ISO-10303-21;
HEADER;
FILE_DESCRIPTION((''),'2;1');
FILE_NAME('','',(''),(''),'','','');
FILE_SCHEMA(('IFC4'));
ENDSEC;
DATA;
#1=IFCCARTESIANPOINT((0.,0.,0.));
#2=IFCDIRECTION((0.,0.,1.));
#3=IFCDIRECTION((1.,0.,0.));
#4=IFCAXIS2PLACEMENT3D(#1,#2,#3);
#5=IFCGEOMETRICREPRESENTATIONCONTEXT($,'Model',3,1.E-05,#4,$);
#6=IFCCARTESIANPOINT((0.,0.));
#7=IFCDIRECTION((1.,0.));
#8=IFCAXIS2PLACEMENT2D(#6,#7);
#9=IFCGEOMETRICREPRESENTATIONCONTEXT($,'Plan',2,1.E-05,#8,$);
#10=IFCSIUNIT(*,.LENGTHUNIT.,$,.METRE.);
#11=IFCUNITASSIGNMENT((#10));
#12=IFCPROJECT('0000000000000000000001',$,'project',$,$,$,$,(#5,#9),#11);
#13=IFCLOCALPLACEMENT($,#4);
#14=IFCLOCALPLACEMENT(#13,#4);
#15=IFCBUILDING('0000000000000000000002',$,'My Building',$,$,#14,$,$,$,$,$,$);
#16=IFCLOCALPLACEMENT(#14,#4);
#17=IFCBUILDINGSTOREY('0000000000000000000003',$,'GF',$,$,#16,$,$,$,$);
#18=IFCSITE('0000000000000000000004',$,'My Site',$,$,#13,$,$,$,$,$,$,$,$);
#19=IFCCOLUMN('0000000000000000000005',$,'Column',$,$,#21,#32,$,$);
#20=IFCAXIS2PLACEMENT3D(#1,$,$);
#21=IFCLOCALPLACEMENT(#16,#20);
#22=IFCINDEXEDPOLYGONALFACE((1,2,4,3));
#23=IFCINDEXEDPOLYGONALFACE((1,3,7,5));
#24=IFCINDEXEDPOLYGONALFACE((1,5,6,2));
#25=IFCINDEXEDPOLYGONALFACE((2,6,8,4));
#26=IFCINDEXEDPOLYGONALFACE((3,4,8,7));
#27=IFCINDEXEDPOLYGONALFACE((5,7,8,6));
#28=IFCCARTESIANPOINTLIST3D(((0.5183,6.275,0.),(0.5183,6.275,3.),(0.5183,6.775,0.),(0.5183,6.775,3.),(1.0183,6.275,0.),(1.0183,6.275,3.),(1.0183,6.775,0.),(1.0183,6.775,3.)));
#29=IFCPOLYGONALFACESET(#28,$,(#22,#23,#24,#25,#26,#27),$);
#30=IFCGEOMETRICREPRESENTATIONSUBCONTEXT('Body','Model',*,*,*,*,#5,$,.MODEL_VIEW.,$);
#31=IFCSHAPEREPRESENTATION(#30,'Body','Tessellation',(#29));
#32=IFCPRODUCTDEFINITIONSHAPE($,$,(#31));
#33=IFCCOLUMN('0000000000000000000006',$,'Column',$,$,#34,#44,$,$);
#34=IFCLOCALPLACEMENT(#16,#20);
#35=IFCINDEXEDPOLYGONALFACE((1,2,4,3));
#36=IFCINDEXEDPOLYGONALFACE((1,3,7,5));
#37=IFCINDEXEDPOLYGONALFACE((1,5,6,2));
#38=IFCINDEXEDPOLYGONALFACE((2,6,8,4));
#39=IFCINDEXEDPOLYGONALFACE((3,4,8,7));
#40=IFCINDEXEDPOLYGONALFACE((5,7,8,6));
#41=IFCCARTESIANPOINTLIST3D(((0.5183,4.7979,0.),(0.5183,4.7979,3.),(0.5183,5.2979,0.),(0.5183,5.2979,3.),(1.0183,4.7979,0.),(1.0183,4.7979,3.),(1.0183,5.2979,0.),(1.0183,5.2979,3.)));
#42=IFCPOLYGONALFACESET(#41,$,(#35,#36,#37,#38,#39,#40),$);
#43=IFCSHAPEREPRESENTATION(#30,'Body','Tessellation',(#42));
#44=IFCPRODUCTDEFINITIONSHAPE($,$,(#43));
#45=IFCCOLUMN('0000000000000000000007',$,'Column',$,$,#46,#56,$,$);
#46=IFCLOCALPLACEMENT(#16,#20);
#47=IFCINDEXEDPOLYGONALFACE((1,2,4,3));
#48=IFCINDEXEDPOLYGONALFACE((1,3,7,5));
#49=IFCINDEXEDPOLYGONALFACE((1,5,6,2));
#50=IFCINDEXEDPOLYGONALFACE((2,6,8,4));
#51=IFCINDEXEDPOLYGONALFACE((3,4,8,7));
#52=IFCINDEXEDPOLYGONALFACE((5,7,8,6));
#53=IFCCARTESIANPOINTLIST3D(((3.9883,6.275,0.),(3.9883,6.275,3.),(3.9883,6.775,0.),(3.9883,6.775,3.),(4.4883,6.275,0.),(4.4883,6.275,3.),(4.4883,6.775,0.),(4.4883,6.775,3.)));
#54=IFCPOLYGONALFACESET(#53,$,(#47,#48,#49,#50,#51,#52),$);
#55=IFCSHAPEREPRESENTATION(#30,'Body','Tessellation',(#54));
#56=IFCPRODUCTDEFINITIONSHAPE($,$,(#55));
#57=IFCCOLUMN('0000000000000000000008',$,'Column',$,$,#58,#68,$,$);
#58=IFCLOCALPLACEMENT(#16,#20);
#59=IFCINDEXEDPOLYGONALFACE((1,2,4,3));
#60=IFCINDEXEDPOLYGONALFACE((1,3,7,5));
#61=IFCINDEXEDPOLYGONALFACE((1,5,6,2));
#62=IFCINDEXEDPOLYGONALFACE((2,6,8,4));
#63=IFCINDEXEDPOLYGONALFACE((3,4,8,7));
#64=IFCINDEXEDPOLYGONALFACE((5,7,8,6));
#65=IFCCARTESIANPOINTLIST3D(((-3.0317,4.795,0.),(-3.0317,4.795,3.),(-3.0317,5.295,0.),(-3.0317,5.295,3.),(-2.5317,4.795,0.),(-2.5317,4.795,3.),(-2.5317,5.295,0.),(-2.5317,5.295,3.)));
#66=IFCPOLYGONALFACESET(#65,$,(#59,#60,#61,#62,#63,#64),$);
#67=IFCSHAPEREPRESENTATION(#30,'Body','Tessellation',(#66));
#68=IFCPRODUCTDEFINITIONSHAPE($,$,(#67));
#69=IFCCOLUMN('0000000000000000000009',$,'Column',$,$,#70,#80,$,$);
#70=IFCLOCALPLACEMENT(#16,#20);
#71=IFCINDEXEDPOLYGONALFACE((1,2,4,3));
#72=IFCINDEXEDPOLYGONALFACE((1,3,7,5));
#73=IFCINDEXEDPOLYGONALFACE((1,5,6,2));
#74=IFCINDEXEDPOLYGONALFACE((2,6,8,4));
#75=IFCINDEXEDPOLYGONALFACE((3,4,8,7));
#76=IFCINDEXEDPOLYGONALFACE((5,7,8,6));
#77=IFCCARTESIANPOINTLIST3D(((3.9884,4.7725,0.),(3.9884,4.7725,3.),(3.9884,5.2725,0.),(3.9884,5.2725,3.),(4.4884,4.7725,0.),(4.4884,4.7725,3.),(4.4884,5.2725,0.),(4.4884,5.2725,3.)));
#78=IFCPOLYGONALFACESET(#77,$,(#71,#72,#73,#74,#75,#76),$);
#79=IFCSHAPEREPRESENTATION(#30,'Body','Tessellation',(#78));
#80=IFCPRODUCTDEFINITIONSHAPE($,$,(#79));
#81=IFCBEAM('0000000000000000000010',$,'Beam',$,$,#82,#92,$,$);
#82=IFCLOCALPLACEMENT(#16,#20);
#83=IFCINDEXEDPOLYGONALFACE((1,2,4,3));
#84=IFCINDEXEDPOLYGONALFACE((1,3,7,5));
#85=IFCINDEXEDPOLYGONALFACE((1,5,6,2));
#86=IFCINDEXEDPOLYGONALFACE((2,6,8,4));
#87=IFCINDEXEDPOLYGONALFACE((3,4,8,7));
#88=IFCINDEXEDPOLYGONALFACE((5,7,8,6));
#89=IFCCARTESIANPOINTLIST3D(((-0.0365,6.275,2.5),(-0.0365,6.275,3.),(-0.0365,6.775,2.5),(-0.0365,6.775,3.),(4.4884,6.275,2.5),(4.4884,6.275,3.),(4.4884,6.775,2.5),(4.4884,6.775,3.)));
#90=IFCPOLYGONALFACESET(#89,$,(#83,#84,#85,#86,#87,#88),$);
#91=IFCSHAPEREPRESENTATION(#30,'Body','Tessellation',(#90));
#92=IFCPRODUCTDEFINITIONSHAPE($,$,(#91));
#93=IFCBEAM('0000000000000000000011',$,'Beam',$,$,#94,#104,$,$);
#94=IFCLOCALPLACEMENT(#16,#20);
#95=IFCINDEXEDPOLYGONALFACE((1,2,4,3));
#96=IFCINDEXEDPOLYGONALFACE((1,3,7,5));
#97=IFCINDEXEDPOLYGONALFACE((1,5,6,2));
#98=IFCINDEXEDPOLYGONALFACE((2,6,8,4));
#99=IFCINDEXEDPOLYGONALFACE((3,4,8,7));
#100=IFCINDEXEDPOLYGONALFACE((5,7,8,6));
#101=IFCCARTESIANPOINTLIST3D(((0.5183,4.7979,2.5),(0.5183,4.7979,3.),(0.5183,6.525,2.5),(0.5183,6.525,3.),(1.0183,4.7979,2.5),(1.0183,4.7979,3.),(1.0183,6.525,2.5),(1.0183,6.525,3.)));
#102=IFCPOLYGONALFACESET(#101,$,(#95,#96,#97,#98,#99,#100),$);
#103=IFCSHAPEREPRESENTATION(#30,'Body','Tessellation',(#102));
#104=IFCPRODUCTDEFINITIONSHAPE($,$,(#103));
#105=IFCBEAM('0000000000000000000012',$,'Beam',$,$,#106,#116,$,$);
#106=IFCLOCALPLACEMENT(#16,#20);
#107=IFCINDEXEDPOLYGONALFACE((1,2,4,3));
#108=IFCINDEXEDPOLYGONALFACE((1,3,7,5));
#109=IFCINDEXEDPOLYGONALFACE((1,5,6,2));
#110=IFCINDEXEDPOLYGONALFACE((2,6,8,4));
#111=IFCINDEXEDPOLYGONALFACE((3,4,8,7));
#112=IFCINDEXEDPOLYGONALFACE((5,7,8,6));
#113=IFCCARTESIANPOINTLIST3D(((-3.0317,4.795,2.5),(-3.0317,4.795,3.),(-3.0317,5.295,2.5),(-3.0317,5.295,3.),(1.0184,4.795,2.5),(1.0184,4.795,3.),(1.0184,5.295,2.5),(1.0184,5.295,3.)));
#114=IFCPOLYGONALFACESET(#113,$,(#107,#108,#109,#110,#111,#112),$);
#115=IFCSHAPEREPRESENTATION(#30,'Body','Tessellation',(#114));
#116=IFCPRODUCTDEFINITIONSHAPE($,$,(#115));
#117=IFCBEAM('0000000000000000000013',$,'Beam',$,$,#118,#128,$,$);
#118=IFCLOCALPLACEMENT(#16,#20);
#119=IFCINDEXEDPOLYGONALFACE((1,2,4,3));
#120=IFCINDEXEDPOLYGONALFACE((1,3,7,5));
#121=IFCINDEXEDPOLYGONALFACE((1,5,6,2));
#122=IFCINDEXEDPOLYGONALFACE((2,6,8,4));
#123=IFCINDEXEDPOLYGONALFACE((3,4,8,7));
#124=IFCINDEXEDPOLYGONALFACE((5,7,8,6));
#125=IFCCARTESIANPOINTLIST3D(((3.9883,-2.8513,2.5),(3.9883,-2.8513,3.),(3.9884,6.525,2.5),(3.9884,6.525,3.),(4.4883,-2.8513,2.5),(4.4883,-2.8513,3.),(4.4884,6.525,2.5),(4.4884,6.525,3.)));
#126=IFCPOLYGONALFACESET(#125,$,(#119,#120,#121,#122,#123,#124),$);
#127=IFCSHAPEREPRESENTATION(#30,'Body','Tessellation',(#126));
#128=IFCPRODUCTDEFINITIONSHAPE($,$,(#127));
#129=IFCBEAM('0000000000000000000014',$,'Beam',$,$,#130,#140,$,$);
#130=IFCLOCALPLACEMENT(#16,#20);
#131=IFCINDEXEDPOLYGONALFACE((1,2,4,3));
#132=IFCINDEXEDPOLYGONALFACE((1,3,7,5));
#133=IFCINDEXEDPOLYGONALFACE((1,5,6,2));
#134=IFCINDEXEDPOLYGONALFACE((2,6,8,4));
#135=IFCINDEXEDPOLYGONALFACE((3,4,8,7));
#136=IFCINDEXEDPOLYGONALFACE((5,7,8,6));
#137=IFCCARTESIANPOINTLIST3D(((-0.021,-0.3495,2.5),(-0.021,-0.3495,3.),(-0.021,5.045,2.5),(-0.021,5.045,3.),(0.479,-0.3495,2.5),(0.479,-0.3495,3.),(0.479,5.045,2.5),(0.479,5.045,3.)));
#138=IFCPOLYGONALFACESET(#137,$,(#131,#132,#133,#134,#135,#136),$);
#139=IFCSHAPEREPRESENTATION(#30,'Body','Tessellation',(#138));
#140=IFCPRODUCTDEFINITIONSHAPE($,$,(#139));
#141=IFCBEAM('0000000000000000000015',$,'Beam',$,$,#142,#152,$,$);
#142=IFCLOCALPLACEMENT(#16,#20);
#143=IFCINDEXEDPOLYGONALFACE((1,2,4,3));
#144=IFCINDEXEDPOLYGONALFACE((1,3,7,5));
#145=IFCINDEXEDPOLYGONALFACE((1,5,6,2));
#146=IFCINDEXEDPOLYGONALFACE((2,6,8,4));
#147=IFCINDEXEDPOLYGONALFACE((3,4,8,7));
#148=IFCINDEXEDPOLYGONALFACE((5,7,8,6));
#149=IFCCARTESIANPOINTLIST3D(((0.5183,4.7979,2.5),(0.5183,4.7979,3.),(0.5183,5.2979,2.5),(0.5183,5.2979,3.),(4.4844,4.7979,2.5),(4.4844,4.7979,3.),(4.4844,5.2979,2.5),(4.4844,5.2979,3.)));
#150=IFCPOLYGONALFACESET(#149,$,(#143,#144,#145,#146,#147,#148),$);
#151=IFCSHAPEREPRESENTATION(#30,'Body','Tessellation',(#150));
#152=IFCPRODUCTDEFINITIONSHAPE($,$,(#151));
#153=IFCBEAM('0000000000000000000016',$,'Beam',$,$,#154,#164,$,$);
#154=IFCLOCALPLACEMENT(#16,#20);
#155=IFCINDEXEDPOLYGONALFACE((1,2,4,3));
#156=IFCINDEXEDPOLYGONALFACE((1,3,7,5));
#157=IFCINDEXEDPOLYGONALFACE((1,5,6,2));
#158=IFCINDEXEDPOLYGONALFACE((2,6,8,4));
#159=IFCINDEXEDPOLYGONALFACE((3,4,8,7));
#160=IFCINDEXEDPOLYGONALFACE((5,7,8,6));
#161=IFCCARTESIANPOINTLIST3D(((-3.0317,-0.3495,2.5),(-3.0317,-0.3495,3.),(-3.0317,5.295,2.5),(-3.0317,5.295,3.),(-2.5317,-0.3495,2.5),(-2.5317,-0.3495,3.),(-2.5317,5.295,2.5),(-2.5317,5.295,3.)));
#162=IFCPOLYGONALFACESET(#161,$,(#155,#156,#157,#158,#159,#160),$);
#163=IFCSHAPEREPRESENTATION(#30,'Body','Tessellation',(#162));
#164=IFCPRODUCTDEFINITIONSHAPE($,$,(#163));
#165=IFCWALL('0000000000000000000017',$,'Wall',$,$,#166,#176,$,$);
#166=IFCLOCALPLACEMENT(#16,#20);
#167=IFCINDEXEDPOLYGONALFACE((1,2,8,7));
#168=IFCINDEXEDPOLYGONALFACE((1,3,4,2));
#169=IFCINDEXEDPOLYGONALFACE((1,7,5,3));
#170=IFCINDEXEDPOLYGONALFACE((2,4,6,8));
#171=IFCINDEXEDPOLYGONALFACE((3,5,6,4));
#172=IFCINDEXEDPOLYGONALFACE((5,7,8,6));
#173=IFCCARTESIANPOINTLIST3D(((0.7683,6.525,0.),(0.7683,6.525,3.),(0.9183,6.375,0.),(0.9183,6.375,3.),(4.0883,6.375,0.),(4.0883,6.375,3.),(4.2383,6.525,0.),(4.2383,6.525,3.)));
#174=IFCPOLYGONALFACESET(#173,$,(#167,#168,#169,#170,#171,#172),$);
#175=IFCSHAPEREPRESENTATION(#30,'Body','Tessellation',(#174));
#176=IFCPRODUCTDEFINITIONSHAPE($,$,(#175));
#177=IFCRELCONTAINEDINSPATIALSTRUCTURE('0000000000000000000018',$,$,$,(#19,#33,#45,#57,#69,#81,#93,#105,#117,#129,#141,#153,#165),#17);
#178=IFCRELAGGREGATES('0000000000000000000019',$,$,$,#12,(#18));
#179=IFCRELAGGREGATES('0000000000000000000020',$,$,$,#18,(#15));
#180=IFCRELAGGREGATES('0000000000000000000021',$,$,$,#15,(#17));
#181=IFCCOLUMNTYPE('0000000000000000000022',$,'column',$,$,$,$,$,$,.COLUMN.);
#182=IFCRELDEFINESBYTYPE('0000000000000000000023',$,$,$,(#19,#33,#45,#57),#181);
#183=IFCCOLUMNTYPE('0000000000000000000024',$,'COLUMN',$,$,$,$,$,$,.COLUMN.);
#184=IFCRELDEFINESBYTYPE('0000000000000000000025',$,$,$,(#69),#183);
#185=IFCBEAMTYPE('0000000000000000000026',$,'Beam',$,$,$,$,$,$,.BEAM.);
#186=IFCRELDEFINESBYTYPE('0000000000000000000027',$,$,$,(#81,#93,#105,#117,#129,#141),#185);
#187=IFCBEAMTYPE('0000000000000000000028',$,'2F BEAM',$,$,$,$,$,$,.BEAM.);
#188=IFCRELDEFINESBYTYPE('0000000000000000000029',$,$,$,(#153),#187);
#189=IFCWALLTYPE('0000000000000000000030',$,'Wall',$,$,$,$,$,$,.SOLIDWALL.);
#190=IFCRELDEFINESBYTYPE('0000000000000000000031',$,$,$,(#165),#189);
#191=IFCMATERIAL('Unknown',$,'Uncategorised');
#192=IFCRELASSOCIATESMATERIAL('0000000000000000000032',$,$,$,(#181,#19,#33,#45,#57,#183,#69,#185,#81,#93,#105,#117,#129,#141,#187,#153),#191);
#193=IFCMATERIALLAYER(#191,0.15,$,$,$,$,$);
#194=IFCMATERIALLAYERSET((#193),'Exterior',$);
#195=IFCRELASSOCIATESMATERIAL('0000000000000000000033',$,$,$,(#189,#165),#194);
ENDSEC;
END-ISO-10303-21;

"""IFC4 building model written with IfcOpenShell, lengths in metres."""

from ifc_helpers import new_model, si_unit, frame, origin_with_axes, origin_2d_with_axis, place, context, subcontext, project, spatial, line, indexed_curve, rectangle, outline, extrude, material, layer, layer_set, layer_usage, material_profile, profile_set, profile_usage, type_object, element, save


model = new_model("IFC4")

# Units and contexts
model_context = context("Model", 3, precision=1e-05, world=origin_with_axes())
plan_context = context("Plan", 2, precision=1e-05, world=origin_2d_with_axis())
body_context_1 = subcontext(model_context, "Body", "Model", "MODEL_VIEW")
ifc_project = project(units=[si_unit("LENGTHUNIT", "METRE")], contexts=[model_context, plan_context])

# Site, building, storey
site_placement = place(None, origin_with_axes())
site = spatial("IfcSite", under=ifc_project, at=site_placement, Name="My Site")
building_placement = place(site_placement, origin_with_axes())
building = spatial("IfcBuilding", under=site, at=building_placement, Name="My Building")
storey_placement = place(building_placement, origin_with_axes())
storey = spatial("IfcBuildingStorey", under=building, at=storey_placement, Name="GF")

# Columns
ifc_material = material(Name="Unknown", Category="Uncategorised")
ifc_material_profile_1 = material_profile(ifc_material, rectangle(XDim=0.5, YDim=0.5))
ifc_profile_set_1 = profile_set([ifc_material_profile_1])
ifc_profile_usage_1 = profile_usage(ifc_profile_set_1, cardinal=5)
column_type_1 = type_object("IfcColumnType", Name="column", PredefinedType="COLUMN", material=ifc_profile_set_1)
column_1_placement = place(storey_placement, frame((0.7683, 6.525, 0.0), z_axis=(0.0, 0.0, 1.0), x_axis=(1.0, 0.0, 0.0)))
element("IfcColumn", 1, at=column_1_placement, inside=storey, type_object=column_type_1, material=ifc_profile_usage_1, Name="Column", context=body_context_1, shape_type="SweptSolid", body=[
    extrude(rectangle(XDim=0.5, YDim=0.5), origin_with_axes(), (0.0, 0.0, 1.0), 3.0),
])
ifc_profile_usage_2 = profile_usage(ifc_profile_set_1, cardinal=5)
column_2_placement = place(storey_placement, frame((0.7683, 5.0479, 0.0), z_axis=(0.0, 0.0, 1.0), x_axis=(1.0, 0.0, 0.0)))
element("IfcColumn", 2, at=column_2_placement, inside=storey, type_object=column_type_1, material=ifc_profile_usage_2, Name="Column", context=body_context_1, shape_type="SweptSolid", body=[
    extrude(rectangle(XDim=0.5, YDim=0.5), origin_with_axes(), (0.0, 0.0, 1.0), 3.0),
])
ifc_profile_usage_3 = profile_usage(ifc_profile_set_1, cardinal=5)
column_3_placement = place(storey_placement, frame((4.2383, 6.525, 0.0), z_axis=(0.0, 0.0, 1.0), x_axis=(1.0, 0.0, 0.0)))
element("IfcColumn", 3, at=column_3_placement, inside=storey, type_object=column_type_1, material=ifc_profile_usage_3, Name="Column", context=body_context_1, shape_type="SweptSolid", body=[
    extrude(rectangle(XDim=0.5, YDim=0.5), origin_with_axes(), (0.0, 0.0, 1.0), 3.0),
])
ifc_profile_usage_4 = profile_usage(ifc_profile_set_1, cardinal=5)
column_4_placement = place(storey_placement, frame((-2.7817, 5.045, 0.0), z_axis=(0.0, 0.0, 1.0), x_axis=(1.0, 0.0, 0.0)))
element("IfcColumn", 4, at=column_4_placement, inside=storey, type_object=column_type_1, material=ifc_profile_usage_4, Name="Column", context=body_context_1, shape_type="SweptSolid", body=[
    extrude(rectangle(XDim=0.5, YDim=0.5), origin_with_axes(), (0.0, 0.0, 1.0), 3.0),
])
ifc_material_profile_2 = material_profile(ifc_material, rectangle(XDim=0.5, YDim=0.5))
ifc_profile_set_2 = profile_set([ifc_material_profile_2])
ifc_profile_usage_5 = profile_usage(ifc_profile_set_2, cardinal=5)
column_type_2 = type_object("IfcColumnType", Name="COLUMN", PredefinedType="COLUMN", material=ifc_profile_set_2)
column_5_placement = place(storey_placement, frame((4.2384, 5.0225, 0.0), z_axis=(0.0, 0.0, 1.0), x_axis=(1.0, 0.0, 0.0)))
element("IfcColumn", 5, at=column_5_placement, inside=storey, type_object=column_type_2, material=ifc_profile_usage_5, Name="Column", context=body_context_1, shape_type="SweptSolid", body=[
    extrude(rectangle(XDim=0.5, YDim=0.5), origin_with_axes(), (0.0, 0.0, 1.0), 3.0),
])

# Beams
ifc_material_profile_3 = material_profile(ifc_material, rectangle(XDim=0.5, YDim=0.5))
ifc_profile_set_3 = profile_set([ifc_material_profile_3])
ifc_profile_usage_6 = profile_usage(ifc_profile_set_3, cardinal=5)
beam_type_1 = type_object("IfcBeamType", Name="Beam", PredefinedType="BEAM", material=ifc_profile_set_3)
beam_1_placement = place(storey_placement, frame((4.4884, 6.525, 2.75), z_axis=(-1.0, 0.0, 0.0), x_axis=(0.0, -1.0, 0.0)))
element("IfcBeam", 6, at=beam_1_placement, inside=storey, type_object=beam_type_1, material=ifc_profile_usage_6, Name="Beam", context=body_context_1, shape_type="SweptSolid", body=[
    extrude(rectangle(XDim=0.5, YDim=0.5), origin_with_axes(), (0.0, 0.0, 1.0), 4.5249),
])
ifc_profile_usage_7 = profile_usage(ifc_profile_set_3, cardinal=5)
beam_2_placement = place(storey_placement, frame((0.7683, 6.525, 2.75), z_axis=(0.0, -1.0, 0.0), x_axis=(1.0, 0.0, 0.0)))
element("IfcBeam", 7, at=beam_2_placement, inside=storey, type_object=beam_type_1, material=ifc_profile_usage_7, Name="Beam", context=body_context_1, shape_type="SweptSolid", body=[
    extrude(rectangle(XDim=0.5, YDim=0.5), origin_with_axes(), (0.0, 0.0, 1.0), 1.7271),
])
ifc_profile_usage_8 = profile_usage(ifc_profile_set_3, cardinal=5)
beam_3_placement = place(storey_placement, frame((-3.0317, 5.045, 2.75), z_axis=(1.0, 0.0, 0.0), x_axis=(0.0, 1.0, 0.0)))
element("IfcBeam", 8, at=beam_3_placement, inside=storey, type_object=beam_type_1, material=ifc_profile_usage_8, Name="Beam", context=body_context_1, shape_type="SweptSolid", body=[
    extrude(rectangle(XDim=0.5, YDim=0.5), origin_with_axes(), (0.0, 0.0, 1.0), 4.05),
])
ifc_profile_usage_9 = profile_usage(ifc_profile_set_3, cardinal=5)
beam_4_placement = place(storey_placement, frame((4.2384, 6.525, 2.75), z_axis=(0.0, -1.0, 0.0), x_axis=(1.0, 0.0, 0.0)))
element("IfcBeam", 9, at=beam_4_placement, inside=storey, type_object=beam_type_1, material=ifc_profile_usage_9, Name="Beam", context=body_context_1, shape_type="SweptSolid", body=[
    extrude(rectangle(XDim=0.5, YDim=0.5), origin_with_axes(), (0.0, 0.0, 1.0), 9.3763),
])
ifc_profile_usage_10 = profile_usage(ifc_profile_set_3, cardinal=5)
beam_5_placement = place(storey_placement, frame((0.229, 5.045, 2.75), z_axis=(0.0, -1.0, 0.0), x_axis=(1.0, 0.0, 0.0)))
element("IfcBeam", 10, at=beam_5_placement, inside=storey, type_object=beam_type_1, material=ifc_profile_usage_10, Name="Beam", context=body_context_1, shape_type="SweptSolid", body=[
    extrude(rectangle(XDim=0.5, YDim=0.5), origin_with_axes(), (0.0, 0.0, 1.0), 5.3945),
])
ifc_profile_usage_11 = profile_usage(ifc_profile_set_3, cardinal=5)
beam_6_placement = place(storey_placement, frame((0.5183, 5.0479, 2.75), z_axis=(1.0, 0.0, 0.0), x_axis=(0.0, 1.0, 0.0)))
element("IfcBeam", 11, at=beam_6_placement, inside=storey, type_object=beam_type_1, material=ifc_profile_usage_11, Name="Beam", context=body_context_1, shape_type="SweptSolid", body=[
    extrude(rectangle(XDim=0.5, YDim=0.5), origin_with_axes(), (0.0, 0.0, 1.0), 3.966),
])
ifc_material_profile_4 = material_profile(ifc_material, rectangle(XDim=0.5, YDim=0.5))
ifc_profile_set_4 = profile_set([ifc_material_profile_4])
ifc_profile_usage_12 = profile_usage(ifc_profile_set_4, cardinal=5)
beam_type_2 = type_object("IfcBeamType", Name="2F BEAM", PredefinedType="BEAM", material=ifc_profile_set_4)
beam_7_placement = place(storey_placement, frame((-2.7817, 5.295, 2.75), z_axis=(0.0, -1.0, 0.0), x_axis=(1.0, 0.0, 0.0)))
element("IfcBeam", 12, at=beam_7_placement, inside=storey, type_object=beam_type_2, material=ifc_profile_usage_12, Name="Beam", context=body_context_1, shape_type="SweptSolid", body=[
    extrude(rectangle(XDim=0.5, YDim=0.5), origin_with_axes(), (0.0, 0.0, 1.0), 5.6445),
])

# Wall
ifc_layer_1 = layer(ifc_material, 0.15)
ifc_layer_set_1 = layer_set([ifc_layer_1], Name="Exterior")
ifc_layer_usage_1 = layer_usage(ifc_layer_set_1, "AXIS2", "POSITIVE", 0.0)
wall_type_1 = type_object("IfcWallType", Name="Wall", PredefinedType="SOLIDWALL", material=ifc_layer_set_1)
wall_1_placement = place(storey_placement, frame((4.2383, 6.525, 0.0), z_axis=(0.0, 0.0, 1.0), x_axis=(-1.0, 0.0, 0.0)))
element("IfcWall", 13, at=wall_1_placement, inside=storey, type_object=wall_type_1, material=ifc_layer_usage_1, Name="Wall", context=body_context_1, shape_type="SweptSolid", body=[
    extrude(outline(indexed_curve([(0.0, 0.0), (0.15, 0.15), (3.32, 0.15), (3.47, 0.0)], segments=[line(1, 2, 3, 4, 1)])), origin_with_axes(), (0.0, 0.0, 1.0), 3.0),
])

save(model, "model.ifc")
